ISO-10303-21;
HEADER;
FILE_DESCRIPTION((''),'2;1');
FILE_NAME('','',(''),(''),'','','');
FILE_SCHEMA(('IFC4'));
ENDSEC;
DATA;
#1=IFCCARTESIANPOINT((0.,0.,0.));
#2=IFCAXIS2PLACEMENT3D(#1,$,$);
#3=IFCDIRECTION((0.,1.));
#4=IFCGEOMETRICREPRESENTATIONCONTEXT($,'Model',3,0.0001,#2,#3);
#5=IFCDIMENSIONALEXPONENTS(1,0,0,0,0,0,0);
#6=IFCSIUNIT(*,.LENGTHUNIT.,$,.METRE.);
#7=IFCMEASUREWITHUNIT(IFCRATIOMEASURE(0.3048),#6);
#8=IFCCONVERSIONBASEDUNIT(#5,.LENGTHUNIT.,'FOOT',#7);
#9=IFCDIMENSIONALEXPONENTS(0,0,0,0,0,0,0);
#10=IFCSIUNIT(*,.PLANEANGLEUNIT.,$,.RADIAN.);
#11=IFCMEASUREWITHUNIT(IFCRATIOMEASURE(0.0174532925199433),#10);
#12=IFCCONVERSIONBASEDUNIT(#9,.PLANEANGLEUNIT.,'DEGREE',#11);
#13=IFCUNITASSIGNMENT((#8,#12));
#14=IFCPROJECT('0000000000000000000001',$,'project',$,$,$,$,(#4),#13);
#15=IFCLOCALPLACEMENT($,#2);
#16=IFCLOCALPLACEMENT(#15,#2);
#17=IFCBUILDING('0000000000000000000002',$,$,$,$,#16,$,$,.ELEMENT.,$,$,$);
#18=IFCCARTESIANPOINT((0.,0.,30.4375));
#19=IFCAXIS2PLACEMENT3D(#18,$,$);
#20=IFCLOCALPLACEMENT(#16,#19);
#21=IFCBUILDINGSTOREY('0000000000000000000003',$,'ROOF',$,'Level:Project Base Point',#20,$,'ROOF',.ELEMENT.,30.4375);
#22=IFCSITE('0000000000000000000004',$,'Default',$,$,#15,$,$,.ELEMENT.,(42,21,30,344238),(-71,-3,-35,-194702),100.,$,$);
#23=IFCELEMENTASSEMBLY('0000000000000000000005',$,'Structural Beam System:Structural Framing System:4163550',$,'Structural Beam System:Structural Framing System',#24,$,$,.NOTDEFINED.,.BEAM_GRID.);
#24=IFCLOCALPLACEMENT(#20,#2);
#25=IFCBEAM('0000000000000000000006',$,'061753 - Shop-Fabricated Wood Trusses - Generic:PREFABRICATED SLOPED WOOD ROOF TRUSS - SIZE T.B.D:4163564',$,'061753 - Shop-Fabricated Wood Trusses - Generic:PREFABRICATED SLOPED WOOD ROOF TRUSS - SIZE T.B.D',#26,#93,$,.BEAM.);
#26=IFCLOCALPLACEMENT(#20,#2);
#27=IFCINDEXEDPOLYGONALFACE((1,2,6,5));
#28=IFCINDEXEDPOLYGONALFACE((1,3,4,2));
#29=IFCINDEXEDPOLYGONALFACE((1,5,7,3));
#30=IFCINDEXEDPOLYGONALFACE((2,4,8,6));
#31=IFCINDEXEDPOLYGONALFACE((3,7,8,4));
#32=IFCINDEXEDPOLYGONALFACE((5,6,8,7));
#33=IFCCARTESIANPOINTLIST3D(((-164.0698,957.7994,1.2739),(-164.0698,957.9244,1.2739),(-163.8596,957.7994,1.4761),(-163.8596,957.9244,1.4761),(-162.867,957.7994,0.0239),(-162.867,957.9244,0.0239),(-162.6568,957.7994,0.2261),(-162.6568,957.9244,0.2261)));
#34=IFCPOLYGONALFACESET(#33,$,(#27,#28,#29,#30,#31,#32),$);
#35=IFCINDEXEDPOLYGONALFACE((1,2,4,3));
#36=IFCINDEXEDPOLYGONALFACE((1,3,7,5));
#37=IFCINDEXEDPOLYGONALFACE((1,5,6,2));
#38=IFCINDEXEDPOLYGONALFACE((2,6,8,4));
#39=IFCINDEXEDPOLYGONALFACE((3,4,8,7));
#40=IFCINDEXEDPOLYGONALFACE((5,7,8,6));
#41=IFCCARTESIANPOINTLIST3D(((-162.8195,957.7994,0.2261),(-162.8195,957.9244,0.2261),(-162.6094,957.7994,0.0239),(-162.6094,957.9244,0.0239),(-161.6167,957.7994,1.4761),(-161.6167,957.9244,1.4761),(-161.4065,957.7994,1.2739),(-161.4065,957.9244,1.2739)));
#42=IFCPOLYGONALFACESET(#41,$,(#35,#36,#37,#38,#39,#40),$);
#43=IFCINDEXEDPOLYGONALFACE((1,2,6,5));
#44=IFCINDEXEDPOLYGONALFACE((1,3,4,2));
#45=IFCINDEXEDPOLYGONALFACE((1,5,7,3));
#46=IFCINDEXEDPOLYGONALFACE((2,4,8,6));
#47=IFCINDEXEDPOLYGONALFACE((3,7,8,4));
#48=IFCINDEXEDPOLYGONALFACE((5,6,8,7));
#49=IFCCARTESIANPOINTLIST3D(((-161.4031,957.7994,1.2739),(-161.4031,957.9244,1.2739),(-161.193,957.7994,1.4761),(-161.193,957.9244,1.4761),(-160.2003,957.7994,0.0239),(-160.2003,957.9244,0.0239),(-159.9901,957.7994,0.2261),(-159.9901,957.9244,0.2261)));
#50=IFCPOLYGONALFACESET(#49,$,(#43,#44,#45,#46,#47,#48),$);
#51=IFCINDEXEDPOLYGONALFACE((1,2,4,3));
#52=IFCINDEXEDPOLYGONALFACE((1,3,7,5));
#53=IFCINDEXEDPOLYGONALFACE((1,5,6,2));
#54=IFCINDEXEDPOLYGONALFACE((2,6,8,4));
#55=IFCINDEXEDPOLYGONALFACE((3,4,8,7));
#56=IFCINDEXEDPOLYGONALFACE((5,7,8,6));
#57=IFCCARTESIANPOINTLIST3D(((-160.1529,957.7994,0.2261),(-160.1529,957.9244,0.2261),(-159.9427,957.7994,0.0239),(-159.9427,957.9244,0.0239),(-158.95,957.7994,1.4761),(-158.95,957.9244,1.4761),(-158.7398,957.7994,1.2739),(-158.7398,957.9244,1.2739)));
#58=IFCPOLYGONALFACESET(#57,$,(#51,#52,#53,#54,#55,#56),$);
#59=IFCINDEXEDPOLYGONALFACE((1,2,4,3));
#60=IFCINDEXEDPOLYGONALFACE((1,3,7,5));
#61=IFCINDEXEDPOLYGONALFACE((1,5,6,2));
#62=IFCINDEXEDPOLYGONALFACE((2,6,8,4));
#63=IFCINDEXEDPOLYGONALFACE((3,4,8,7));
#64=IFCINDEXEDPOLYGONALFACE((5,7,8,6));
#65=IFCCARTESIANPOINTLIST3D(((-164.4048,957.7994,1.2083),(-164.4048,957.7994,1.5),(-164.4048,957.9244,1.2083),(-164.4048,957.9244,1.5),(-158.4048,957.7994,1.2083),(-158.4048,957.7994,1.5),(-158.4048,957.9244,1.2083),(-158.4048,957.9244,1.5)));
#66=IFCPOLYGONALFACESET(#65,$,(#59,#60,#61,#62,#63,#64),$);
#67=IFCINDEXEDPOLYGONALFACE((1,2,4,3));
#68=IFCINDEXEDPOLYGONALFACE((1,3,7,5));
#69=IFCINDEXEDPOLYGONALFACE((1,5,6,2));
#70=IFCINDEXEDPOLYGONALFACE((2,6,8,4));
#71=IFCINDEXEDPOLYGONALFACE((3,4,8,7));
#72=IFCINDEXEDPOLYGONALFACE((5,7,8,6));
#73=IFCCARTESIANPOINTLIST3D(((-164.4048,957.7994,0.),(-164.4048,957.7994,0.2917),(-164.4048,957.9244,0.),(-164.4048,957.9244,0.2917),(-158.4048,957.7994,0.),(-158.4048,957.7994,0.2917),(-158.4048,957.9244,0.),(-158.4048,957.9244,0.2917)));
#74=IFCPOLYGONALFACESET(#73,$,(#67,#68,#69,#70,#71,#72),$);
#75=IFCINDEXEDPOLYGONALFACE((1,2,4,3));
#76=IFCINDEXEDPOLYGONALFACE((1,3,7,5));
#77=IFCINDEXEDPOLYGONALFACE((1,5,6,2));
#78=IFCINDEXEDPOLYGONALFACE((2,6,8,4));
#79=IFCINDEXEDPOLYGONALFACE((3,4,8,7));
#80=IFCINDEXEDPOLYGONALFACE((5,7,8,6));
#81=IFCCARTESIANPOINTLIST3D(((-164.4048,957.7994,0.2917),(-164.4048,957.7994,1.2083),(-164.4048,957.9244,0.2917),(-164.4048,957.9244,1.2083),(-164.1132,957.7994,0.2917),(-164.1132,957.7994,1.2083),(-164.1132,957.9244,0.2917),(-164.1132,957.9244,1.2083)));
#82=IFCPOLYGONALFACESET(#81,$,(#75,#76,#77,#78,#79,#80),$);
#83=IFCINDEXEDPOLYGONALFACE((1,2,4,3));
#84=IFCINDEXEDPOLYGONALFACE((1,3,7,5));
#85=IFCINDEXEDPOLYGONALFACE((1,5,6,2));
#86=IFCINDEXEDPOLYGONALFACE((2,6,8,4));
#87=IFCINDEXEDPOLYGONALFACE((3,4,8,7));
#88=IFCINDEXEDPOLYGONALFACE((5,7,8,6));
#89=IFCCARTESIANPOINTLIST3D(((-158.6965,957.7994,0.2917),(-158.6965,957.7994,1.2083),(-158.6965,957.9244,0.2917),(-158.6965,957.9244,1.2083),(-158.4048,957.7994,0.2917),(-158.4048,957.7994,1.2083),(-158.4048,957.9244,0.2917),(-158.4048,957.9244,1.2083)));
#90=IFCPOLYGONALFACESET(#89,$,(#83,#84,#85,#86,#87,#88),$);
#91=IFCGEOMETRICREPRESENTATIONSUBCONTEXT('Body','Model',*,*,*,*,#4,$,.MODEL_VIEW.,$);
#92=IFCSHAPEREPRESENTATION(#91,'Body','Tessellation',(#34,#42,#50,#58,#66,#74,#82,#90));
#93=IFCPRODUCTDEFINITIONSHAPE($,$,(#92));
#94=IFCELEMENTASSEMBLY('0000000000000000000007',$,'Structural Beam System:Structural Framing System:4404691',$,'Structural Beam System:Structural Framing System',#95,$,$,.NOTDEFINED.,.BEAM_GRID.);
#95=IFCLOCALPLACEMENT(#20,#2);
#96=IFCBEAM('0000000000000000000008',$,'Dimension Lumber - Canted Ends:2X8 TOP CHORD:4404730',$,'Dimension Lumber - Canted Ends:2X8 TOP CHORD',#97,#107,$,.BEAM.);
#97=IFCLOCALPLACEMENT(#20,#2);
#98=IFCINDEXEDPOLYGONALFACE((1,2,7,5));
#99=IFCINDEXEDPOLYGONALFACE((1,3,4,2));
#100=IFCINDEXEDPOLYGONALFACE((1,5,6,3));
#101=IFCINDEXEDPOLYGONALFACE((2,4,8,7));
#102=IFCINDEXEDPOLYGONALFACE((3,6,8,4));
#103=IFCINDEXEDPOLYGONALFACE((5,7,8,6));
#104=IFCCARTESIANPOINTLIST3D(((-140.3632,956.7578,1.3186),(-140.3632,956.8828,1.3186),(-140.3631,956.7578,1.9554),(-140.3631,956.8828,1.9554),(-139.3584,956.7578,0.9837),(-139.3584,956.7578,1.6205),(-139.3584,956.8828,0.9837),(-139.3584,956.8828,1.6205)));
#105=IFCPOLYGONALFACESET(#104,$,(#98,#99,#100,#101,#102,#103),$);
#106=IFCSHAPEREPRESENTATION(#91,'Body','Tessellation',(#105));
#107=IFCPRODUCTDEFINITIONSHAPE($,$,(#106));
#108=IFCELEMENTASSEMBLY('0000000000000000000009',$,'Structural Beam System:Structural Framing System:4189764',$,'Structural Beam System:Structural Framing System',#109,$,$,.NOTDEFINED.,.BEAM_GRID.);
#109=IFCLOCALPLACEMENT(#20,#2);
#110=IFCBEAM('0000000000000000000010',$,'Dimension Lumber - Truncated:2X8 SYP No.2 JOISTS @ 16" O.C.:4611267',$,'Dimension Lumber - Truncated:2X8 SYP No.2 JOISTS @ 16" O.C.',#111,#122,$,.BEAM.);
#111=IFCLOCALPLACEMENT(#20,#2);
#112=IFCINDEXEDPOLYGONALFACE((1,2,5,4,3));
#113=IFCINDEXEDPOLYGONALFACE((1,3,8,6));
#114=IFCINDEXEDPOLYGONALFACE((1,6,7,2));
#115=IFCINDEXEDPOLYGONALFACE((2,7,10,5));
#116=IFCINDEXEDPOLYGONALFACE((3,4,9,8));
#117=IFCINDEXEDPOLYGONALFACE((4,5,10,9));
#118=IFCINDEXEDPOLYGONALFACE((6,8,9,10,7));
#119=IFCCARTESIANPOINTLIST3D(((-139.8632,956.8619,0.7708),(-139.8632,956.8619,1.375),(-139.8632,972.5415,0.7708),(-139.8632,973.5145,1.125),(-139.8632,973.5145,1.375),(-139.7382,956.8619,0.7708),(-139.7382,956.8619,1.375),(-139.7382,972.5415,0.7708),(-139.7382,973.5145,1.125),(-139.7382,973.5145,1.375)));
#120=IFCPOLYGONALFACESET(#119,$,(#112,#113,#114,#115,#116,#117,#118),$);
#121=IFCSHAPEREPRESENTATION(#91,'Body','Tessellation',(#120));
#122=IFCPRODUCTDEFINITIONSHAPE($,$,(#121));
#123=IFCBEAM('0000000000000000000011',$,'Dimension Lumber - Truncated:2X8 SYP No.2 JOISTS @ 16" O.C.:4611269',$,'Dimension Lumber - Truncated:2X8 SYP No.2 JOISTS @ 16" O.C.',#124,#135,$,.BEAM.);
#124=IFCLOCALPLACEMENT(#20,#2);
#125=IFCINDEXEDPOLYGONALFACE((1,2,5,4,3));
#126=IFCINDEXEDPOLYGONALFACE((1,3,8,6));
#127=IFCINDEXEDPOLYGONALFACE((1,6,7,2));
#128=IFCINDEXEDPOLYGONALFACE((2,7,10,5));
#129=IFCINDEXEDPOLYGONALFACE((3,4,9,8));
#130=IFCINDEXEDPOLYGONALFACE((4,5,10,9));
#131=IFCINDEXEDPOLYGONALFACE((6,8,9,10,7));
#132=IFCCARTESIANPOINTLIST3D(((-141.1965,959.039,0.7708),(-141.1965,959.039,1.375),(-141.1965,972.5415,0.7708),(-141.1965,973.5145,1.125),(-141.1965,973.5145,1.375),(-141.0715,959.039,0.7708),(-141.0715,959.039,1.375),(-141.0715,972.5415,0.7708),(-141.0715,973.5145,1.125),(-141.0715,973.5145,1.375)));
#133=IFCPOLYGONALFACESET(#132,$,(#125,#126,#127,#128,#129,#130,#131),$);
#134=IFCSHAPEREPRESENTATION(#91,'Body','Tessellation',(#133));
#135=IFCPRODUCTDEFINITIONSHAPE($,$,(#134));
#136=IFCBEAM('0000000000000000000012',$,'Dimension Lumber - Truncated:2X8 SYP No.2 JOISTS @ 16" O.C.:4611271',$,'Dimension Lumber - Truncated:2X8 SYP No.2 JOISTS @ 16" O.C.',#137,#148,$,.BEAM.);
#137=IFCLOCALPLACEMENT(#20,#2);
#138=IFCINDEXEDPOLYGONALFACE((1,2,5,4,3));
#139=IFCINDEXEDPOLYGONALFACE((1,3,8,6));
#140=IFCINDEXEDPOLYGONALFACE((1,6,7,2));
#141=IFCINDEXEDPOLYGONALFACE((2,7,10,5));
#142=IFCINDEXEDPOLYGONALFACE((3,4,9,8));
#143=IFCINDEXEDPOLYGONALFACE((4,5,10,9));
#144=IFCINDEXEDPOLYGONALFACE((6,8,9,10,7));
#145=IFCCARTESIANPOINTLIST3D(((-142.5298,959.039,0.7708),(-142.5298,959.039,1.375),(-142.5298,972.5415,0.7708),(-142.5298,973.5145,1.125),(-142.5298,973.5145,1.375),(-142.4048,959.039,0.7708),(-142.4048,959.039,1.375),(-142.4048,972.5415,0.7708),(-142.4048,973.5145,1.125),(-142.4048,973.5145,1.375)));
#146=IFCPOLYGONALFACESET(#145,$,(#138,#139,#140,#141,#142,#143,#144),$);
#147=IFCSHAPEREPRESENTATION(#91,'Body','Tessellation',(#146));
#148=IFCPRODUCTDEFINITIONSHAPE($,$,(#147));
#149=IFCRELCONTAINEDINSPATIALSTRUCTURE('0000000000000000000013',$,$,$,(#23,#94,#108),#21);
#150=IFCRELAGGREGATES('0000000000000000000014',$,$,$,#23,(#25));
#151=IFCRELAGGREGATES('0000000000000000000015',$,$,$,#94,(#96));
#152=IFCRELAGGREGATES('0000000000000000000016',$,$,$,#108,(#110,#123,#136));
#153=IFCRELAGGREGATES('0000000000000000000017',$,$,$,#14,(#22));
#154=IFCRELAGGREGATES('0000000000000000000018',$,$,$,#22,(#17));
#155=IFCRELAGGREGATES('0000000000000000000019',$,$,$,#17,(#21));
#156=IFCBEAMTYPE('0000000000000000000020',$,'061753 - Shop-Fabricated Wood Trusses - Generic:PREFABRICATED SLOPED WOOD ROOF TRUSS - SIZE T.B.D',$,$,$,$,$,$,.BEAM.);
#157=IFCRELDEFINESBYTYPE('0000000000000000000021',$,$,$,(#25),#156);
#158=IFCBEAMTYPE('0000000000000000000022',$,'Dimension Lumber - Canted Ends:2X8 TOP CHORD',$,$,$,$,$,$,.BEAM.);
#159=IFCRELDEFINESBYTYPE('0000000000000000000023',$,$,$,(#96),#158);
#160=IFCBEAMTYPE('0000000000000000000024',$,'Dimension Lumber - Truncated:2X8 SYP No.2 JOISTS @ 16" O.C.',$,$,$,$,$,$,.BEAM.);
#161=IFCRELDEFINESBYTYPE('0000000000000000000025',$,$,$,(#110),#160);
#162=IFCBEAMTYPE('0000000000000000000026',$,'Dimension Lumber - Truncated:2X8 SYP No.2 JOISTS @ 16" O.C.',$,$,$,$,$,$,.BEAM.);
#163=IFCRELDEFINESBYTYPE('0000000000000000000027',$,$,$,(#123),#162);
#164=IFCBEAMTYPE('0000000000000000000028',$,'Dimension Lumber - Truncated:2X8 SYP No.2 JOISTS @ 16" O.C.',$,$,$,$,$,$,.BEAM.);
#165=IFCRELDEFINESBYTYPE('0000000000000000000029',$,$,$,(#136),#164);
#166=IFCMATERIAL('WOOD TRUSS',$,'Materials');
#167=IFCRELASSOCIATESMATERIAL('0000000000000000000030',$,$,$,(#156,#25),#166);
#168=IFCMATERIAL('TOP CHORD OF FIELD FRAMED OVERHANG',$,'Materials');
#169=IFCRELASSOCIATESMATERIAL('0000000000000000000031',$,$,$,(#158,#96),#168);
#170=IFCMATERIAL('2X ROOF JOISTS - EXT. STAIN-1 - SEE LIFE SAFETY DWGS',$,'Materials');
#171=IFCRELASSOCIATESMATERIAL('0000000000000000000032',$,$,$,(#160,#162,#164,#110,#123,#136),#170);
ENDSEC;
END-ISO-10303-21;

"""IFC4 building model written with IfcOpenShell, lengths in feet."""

from ifc_helpers import new_model, entity, si_unit, converted_unit, direction, frame, frame_2d, origin, origin_2d_with_axis, place, context, subcontext, project, spatial, rectangle, extrude, clip, halfspace, source, transform, mapped, material, material_profile, profile_set, profile_usage, type_object, type_shapes, element, aggregate, save


model = new_model("IFC4")

# Units and contexts
model_context = context("Model", 3, precision=0.0001, world=origin(), true_north=direction((0.0, 1.0)))
body_context = subcontext(model_context, "Body", "Model", "MODEL_VIEW")
ifc_project = project(units=[converted_unit("LENGTHUNIT", "FOOT", entity("IfcRatioMeasure", 0.3048), si_unit("LENGTHUNIT", "METRE"), dimensions=[1, 0, 0, 0, 0, 0, 0]), converted_unit("PLANEANGLEUNIT", "DEGREE", entity("IfcRatioMeasure", 0.0174532925199433), si_unit("PLANEANGLEUNIT", "RADIAN"), dimensions=[0, 0, 0, 0, 0, 0, 0])], contexts=[model_context])

# Site, building, storey
site_placement = place(None, origin())
site = spatial("IfcSite", under=ifc_project, at=site_placement, Name="Default", CompositionType="ELEMENT", RefLatitude=(42, 21, 30, 344238), RefLongitude=(-71, -3, -35, -194702), RefElevation=100.0)
building_placement = place(site_placement, origin())
building = spatial("IfcBuilding", under=site, at=building_placement, CompositionType="ELEMENT")
storey_placement = place(building_placement, frame((0.0, 0.0, 30.4375)))
storey = spatial("IfcBuildingStorey", under=building, at=storey_placement, Name="ROOF", ObjectType="Level:Project Base Point", LongName="ROOF", CompositionType="ELEMENT", Elevation=30.4375)

# Element assembly, beam
assembly_1_placement = place(storey_placement, origin())
assembly_1 = element("IfcElementAssembly", 1, at=assembly_1_placement, inside=storey, Name="Structural Beam System:Structural Framing System:4163550", ObjectType="Structural Beam System:Structural Framing System", AssemblyPlace="NOTDEFINED", PredefinedType="BEAM_GRID")
ifc_material_1 = material(Name="WOOD TRUSS", Category="Materials")
ifc_material_profile_1 = material_profile(ifc_material_1, rectangle(XDim=1.7347, YDim=0.125, at=origin_2d_with_axis()), Name="PREFABRICATED SLOPED WOOD ROOF TRUSS - SIZE T.B.D")
ifc_material_profile_2 = material_profile(ifc_material_1, rectangle(XDim=1.7347, YDim=0.125, at=frame_2d((0.0, 0.0), x_axis=(1.0, 0.0))), Name="PREFABRICATED SLOPED WOOD ROOF TRUSS - SIZE T.B.D")
ifc_material_profile_3 = material_profile(ifc_material_1, rectangle(XDim=1.7347, YDim=0.125, at=origin_2d_with_axis()), Name="PREFABRICATED SLOPED WOOD ROOF TRUSS - SIZE T.B.D")
ifc_material_profile_4 = material_profile(ifc_material_1, rectangle(XDim=1.7347, YDim=0.125, at=origin_2d_with_axis()), Name="PREFABRICATED SLOPED WOOD ROOF TRUSS - SIZE T.B.D")
ifc_material_profile_5 = material_profile(ifc_material_1, rectangle(XDim=1.7347, YDim=0.125, at=frame_2d((0.0, 0.0), x_axis=(1.0, 0.0))), Name="PREFABRICATED SLOPED WOOD ROOF TRUSS - SIZE T.B.D")
ifc_material_profile_6 = material_profile(ifc_material_1, rectangle(XDim=1.7347, YDim=0.125, at=frame_2d((0.0, 0.0), x_axis=(1.0, 0.0))), Name="PREFABRICATED SLOPED WOOD ROOF TRUSS - SIZE T.B.D")
ifc_material_profile_7 = material_profile(ifc_material_1, rectangle(XDim=1.7347, YDim=0.125, at=frame_2d((0.0, 0.0), x_axis=(1.0, 0.0))), Name="PREFABRICATED SLOPED WOOD ROOF TRUSS - SIZE T.B.D")
ifc_material_profile_8 = material_profile(ifc_material_1, rectangle(XDim=1.7347, YDim=0.125, at=frame_2d((0.0, 0.0), x_axis=(1.0, 0.0))), Name="PREFABRICATED SLOPED WOOD ROOF TRUSS - SIZE T.B.D")
ifc_material_profile_9 = material_profile(ifc_material_1, rectangle(XDim=1.7347, YDim=0.125, at=origin_2d_with_axis()), Name="PREFABRICATED SLOPED WOOD ROOF TRUSS - SIZE T.B.D")
ifc_material_profile_10 = material_profile(ifc_material_1, rectangle(XDim=1.7347, YDim=0.125, at=frame_2d((0.0, 0.0), x_axis=(1.0, 0.0))), Name="PREFABRICATED SLOPED WOOD ROOF TRUSS - SIZE T.B.D")
ifc_material_profile_11 = material_profile(ifc_material_1, rectangle(XDim=0.2917, YDim=0.125, at=frame_2d((0.0, 0.0), x_axis=(1.0, 0.0))), Name="PREFABRICATED SLOPED WOOD ROOF TRUSS - SIZE T.B.D")
ifc_material_profile_12 = material_profile(ifc_material_1, rectangle(XDim=0.2917, YDim=0.125, at=frame_2d((0.0, 0.0), x_axis=(1.0, 0.0))), Name="PREFABRICATED SLOPED WOOD ROOF TRUSS - SIZE T.B.D")
ifc_material_profile_13 = material_profile(ifc_material_1, rectangle(XDim=0.9167, YDim=0.125, at=frame_2d((0.0, 0.0), x_axis=(1.0, 0.0))), Name="PREFABRICATED SLOPED WOOD ROOF TRUSS - SIZE T.B.D")
ifc_material_profile_14 = material_profile(ifc_material_1, rectangle(XDim=0.9167, YDim=0.125, at=frame_2d((0.0, 0.0), x_axis=(1.0, 0.0))), Name="PREFABRICATED SLOPED WOOD ROOF TRUSS - SIZE T.B.D")
ifc_profile_set_1 = profile_set([ifc_material_profile_1, ifc_material_profile_2, ifc_material_profile_3, ifc_material_profile_4, ifc_material_profile_5, ifc_material_profile_6, ifc_material_profile_7, ifc_material_profile_8, ifc_material_profile_9, ifc_material_profile_10, ifc_material_profile_11, ifc_material_profile_12, ifc_material_profile_13, ifc_material_profile_14], Name="PREFABRICATED SLOPED WOOD ROOF TRUSS - SIZE T.B.D")
ifc_profile_usage_1 = profile_usage(ifc_profile_set_1, cardinal=8)
beam_type_1 = type_object("IfcBeamType", Name="061753 - Shop-Fabricated Wood Trusses - Generic:PREFABRICATED SLOPED WOOD ROOF TRUSS - SIZE T.B.D", PredefinedType="BEAM", material=ifc_profile_set_1)
shared_shape_1 = source(origin(), body_context, "Body", "SweptSolid", [
    extrude(rectangle(XDim=1.7347, YDim=0.125, at=frame_2d((0.0, 0.0), x_axis=(1.0, 0.0))), frame((1.8534, 0.0, 0.1011), z_axis=(0.720569, 0.0, -0.693383), x_axis=(0.693383, 0.0, 0.720569)), (0.0, 0.0, 1.0), 0.2917),
    extrude(rectangle(XDim=1.7347, YDim=0.125, at=frame_2d((0.0, 0.0), x_axis=(1.0, 0.0))), frame((0.6031, 0.0, -0.1011), z_axis=(0.720569, 0.0, 0.693383), x_axis=(0.693383, 0.0, -0.720569)), (0.0, 0.0, 1.0), 0.2917),
    extrude(rectangle(XDim=1.7347, YDim=0.125, at=frame_2d((0.0, 0.0), x_axis=(1.0, 0.0))), frame((-0.8133, 0.0, 0.1011), z_axis=(0.720569, 0.0, -0.693383), x_axis=(0.693383, 0.0, 0.720569)), (0.0, 0.0, 1.0), 0.2917),
    extrude(rectangle(XDim=1.7347, YDim=0.125, at=frame_2d((0.0, 0.0), x_axis=(1.0, 0.0))), frame((-2.0636, 0.0, -0.1011), z_axis=(0.720569, 0.0, 0.693383), x_axis=(0.693383, 0.0, -0.720569)), (0.0, 0.0, 1.0), 0.2917),
    extrude(rectangle(XDim=0.2917, YDim=0.125, at=frame_2d((0.0, 0.0), x_axis=(1.0, 0.0))), frame((-3.0, 0.0, 0.6042), z_axis=(1.0, 0.0, 0.0), x_axis=(0.0, 0.0, -1.0)), (0.0, 0.0, 1.0), 6.0),
    extrude(rectangle(XDim=0.2917, YDim=0.125, at=frame_2d((0.0, 0.0), x_axis=(1.0, 0.0))), frame((-3.0, 0.0, -0.6042), z_axis=(1.0, 0.0, 0.0), x_axis=(0.0, 0.0, -1.0)), (0.0, 0.0, 1.0), 6.0),
    extrude(rectangle(XDim=0.9167, YDim=0.125, at=frame_2d((0.0, 0.0), x_axis=(1.0, 0.0))), frame((2.7083, 0.0, 0.0), z_axis=(1.0, 0.0, 0.0), x_axis=(0.0, 0.0, -1.0)), (0.0, 0.0, 1.0), 0.2917),
    extrude(rectangle(XDim=0.9167, YDim=0.125, at=frame_2d((0.0, 0.0), x_axis=(1.0, 0.0))), frame((-3.0, 0.0, 0.0), z_axis=(1.0, 0.0, 0.0), x_axis=(0.0, 0.0, -1.0)), (0.0, 0.0, 1.0), 0.2917),
])
type_shapes(beam_type_1, [shared_shape_1])
beam_1_placement = place(assembly_1_placement, frame((-161.4048, 957.8619, 0.75), z_axis=(0.0, 0.0, 1.0), x_axis=(-1.0, 0.0, 0.0)))
beam_1 = element("IfcBeam", 2, at=beam_1_placement, type_object=beam_type_1, material=ifc_profile_usage_1, Name="061753 - Shop-Fabricated Wood Trusses - Generic:PREFABRICATED SLOPED WOOD ROOF TRUSS - SIZE T.B.D:4163564", ObjectType="061753 - Shop-Fabricated Wood Trusses - Generic:PREFABRICATED SLOPED WOOD ROOF TRUSS - SIZE T.B.D", PredefinedType="BEAM", context=body_context, shape_type="MappedRepresentation", body=[
    mapped(shared_shape_1, transform((0.0, 0.0, 0.0), scale=1.0)),
])
aggregate(assembly_1, [beam_1])

# Element assembly, beam
assembly_2_placement = place(storey_placement, origin())
assembly_2 = element("IfcElementAssembly", 3, at=assembly_2_placement, inside=storey, Name="Structural Beam System:Structural Framing System:4404691", ObjectType="Structural Beam System:Structural Framing System", AssemblyPlace="NOTDEFINED", PredefinedType="BEAM_GRID")
ifc_material_2 = material(Name="TOP CHORD OF FIELD FRAMED OVERHANG", Category="Materials")
ifc_material_profile_15 = material_profile(ifc_material_2, rectangle(XDim=0.6042, YDim=0.125, at=origin_2d_with_axis()), Name="2X8 TOP CHORD")
ifc_profile_set_2 = profile_set([ifc_material_profile_15], Name="2X8 TOP CHORD")
ifc_profile_usage_2 = profile_usage(ifc_profile_set_2, cardinal=8)
beam_type_2 = type_object("IfcBeamType", Name="Dimension Lumber - Canted Ends:2X8 TOP CHORD", PredefinedType="BEAM", material=ifc_profile_set_2)
shared_shape_2 = source(origin(), body_context, "Body", "Clipping", [
    clip(clip(extrude(rectangle(XDim=0.6042, YDim=0.125, at=frame_2d((0.0, 0.0), x_axis=(1.0, 0.0))), frame((-0.5296, 0.0, 0.0), z_axis=(1.0, 0.0, 0.0), x_axis=(0.0, 0.0, -1.0)), (0.0, 0.0, 1.0), 1.2605), halfspace(frame((0.5296, -0.0625, -0.3021), z_axis=(0.948711, 0.0, -0.316146), x_axis=(0.0, 1.0, 0.0)), False)), halfspace(frame((-0.3282, -0.0625, 0.3021), z_axis=(-0.948711, 0.0, 0.316146), x_axis=(0.0, 1.0, 0.0)), False)),
])
type_shapes(beam_type_2, [shared_shape_2])
beam_2_placement = place(assembly_2_placement, frame((-139.7653, 956.8203, 1.4377), z_axis=(0.316228, 0.0, 0.948683), x_axis=(-0.948683, 0.0, 0.316228)))
beam_2 = element("IfcBeam", 4, at=beam_2_placement, type_object=beam_type_2, material=ifc_profile_usage_2, Name="Dimension Lumber - Canted Ends:2X8 TOP CHORD:4404730", ObjectType="Dimension Lumber - Canted Ends:2X8 TOP CHORD", PredefinedType="BEAM", context=body_context, shape_type="MappedRepresentation", body=[
    mapped(shared_shape_2, transform((0.0, 0.0, 0.0), scale=1.0)),
])
aggregate(assembly_2, [beam_2])

# Element assembly, beams
assembly_3_placement = place(storey_placement, origin())
assembly_3 = element("IfcElementAssembly", 5, at=assembly_3_placement, inside=storey, Name="Structural Beam System:Structural Framing System:4189764", ObjectType="Structural Beam System:Structural Framing System", AssemblyPlace="NOTDEFINED", PredefinedType="BEAM_GRID")
ifc_material_3 = material(Name="2X ROOF JOISTS - EXT. STAIN-1 - SEE LIFE SAFETY DWGS", Category="Materials")
ifc_material_profile_16 = material_profile(ifc_material_3, rectangle(XDim=0.6042, YDim=0.125, at=frame_2d((0.0, 0.0), x_axis=(0.0, 1.0))), Name="2X8 SYP No.2 JOISTS @ 16\" O.C.")
ifc_profile_set_3 = profile_set([ifc_material_profile_16], Name="2X8 SYP No.2 JOISTS @ 16\" O.C.")
ifc_profile_usage_3 = profile_usage(ifc_profile_set_3, cardinal=8)
beam_type_3 = type_object("IfcBeamType", Name="Dimension Lumber - Truncated:2X8 SYP No.2 JOISTS @ 16\" O.C.", PredefinedType="BEAM", material=ifc_profile_set_3)
shared_shape_3 = source(origin(), body_context, "Body", "Clipping", [
    clip(extrude(rectangle(XDim=0.6042, YDim=0.125, at=frame_2d((0.0, 0.0), x_axis=(0.0, 1.0))), frame((-8.3263, 0.0, 0.0), z_axis=(1.0, 0.0, 0.0), x_axis=(0.0, 1.0, 0.0)), (0.0, 0.0, 1.0), 16.6526), halfspace(frame((-7.3532, -0.0625, -0.3021), z_axis=(-0.34202, 0.0, -0.939693), x_axis=(0.0, 1.0, 0.0)), False)),
])
type_shapes(beam_type_3, [shared_shape_3])
beam_3_placement = place(assembly_3_placement, frame((-139.8007, 965.1882, 1.0729), z_axis=(0.0, 0.0, 1.0), x_axis=(0.0, -1.0, 0.0)))
beam_3 = element("IfcBeam", 6, at=beam_3_placement, type_object=beam_type_3, material=ifc_profile_usage_3, Name="Dimension Lumber - Truncated:2X8 SYP No.2 JOISTS @ 16\" O.C.:4611267", ObjectType="Dimension Lumber - Truncated:2X8 SYP No.2 JOISTS @ 16\" O.C.", PredefinedType="BEAM", context=body_context, shape_type="MappedRepresentation", body=[
    mapped(shared_shape_3, transform((0.0, 0.0, 0.0), scale=1.0)),
])
ifc_profile_usage_4 = profile_usage(ifc_profile_set_3, cardinal=8)
beam_type_4 = type_object("IfcBeamType", Name="Dimension Lumber - Truncated:2X8 SYP No.2 JOISTS @ 16\" O.C.", PredefinedType="BEAM", material=ifc_profile_set_3)
shared_shape_4 = source(origin(), body_context, "Body", "Clipping", [
    clip(extrude(rectangle(XDim=0.6042, YDim=0.125, at=frame_2d((0.0, 0.0), x_axis=(0.0, 1.0))), frame((-7.2378, 0.0, 0.0), z_axis=(1.0, 0.0, 0.0), x_axis=(0.0, 1.0, 0.0)), (0.0, 0.0, 1.0), 14.4755), halfspace(frame((-6.2647, -0.0625, -0.3021), z_axis=(-0.34202, 0.0, -0.939693), x_axis=(0.0, 1.0, 0.0)), False)),
])
type_shapes(beam_type_4, [shared_shape_4])
beam_4_placement = place(assembly_3_placement, frame((-141.134, 966.2768, 1.0729), z_axis=(0.0, 0.0, 1.0), x_axis=(0.0, -1.0, 0.0)))
beam_4 = element("IfcBeam", 7, at=beam_4_placement, type_object=beam_type_4, material=ifc_profile_usage_4, Name="Dimension Lumber - Truncated:2X8 SYP No.2 JOISTS @ 16\" O.C.:4611269", ObjectType="Dimension Lumber - Truncated:2X8 SYP No.2 JOISTS @ 16\" O.C.", PredefinedType="BEAM", context=body_context, shape_type="MappedRepresentation", body=[
    mapped(shared_shape_4, transform((0.0, 0.0, 0.0), scale=1.0)),
])
ifc_profile_usage_5 = profile_usage(ifc_profile_set_3, cardinal=8)
beam_type_5 = type_object("IfcBeamType", Name="Dimension Lumber - Truncated:2X8 SYP No.2 JOISTS @ 16\" O.C.", PredefinedType="BEAM", material=ifc_profile_set_3)
shared_shape_5 = source(origin(), body_context, "Body", "Clipping", [
    clip(extrude(rectangle(XDim=0.6042, YDim=0.125, at=frame_2d((0.0, 0.0), x_axis=(0.0, 1.0))), frame((-7.2378, 0.0, 0.0), z_axis=(1.0, 0.0, 0.0), x_axis=(0.0, 1.0, 0.0)), (0.0, 0.0, 1.0), 14.4755), halfspace(frame((-6.2647, -0.0625, -0.3021), z_axis=(-0.34202, 0.0, -0.939693), x_axis=(0.0, 1.0, 0.0)), False)),
])
type_shapes(beam_type_5, [shared_shape_5])
beam_5_placement = place(assembly_3_placement, frame((-142.4673, 966.2768, 1.0729), z_axis=(0.0, 0.0, 1.0), x_axis=(0.0, -1.0, 0.0)))
beam_5 = element("IfcBeam", 8, at=beam_5_placement, type_object=beam_type_5, material=ifc_profile_usage_5, Name="Dimension Lumber - Truncated:2X8 SYP No.2 JOISTS @ 16\" O.C.:4611271", ObjectType="Dimension Lumber - Truncated:2X8 SYP No.2 JOISTS @ 16\" O.C.", PredefinedType="BEAM", context=body_context, shape_type="MappedRepresentation", body=[
    mapped(shared_shape_5, transform((0.0, 0.0, 0.0), scale=1.0)),
])
aggregate(assembly_3, [beam_3, beam_4, beam_5])

save(model, "model.ifc")
